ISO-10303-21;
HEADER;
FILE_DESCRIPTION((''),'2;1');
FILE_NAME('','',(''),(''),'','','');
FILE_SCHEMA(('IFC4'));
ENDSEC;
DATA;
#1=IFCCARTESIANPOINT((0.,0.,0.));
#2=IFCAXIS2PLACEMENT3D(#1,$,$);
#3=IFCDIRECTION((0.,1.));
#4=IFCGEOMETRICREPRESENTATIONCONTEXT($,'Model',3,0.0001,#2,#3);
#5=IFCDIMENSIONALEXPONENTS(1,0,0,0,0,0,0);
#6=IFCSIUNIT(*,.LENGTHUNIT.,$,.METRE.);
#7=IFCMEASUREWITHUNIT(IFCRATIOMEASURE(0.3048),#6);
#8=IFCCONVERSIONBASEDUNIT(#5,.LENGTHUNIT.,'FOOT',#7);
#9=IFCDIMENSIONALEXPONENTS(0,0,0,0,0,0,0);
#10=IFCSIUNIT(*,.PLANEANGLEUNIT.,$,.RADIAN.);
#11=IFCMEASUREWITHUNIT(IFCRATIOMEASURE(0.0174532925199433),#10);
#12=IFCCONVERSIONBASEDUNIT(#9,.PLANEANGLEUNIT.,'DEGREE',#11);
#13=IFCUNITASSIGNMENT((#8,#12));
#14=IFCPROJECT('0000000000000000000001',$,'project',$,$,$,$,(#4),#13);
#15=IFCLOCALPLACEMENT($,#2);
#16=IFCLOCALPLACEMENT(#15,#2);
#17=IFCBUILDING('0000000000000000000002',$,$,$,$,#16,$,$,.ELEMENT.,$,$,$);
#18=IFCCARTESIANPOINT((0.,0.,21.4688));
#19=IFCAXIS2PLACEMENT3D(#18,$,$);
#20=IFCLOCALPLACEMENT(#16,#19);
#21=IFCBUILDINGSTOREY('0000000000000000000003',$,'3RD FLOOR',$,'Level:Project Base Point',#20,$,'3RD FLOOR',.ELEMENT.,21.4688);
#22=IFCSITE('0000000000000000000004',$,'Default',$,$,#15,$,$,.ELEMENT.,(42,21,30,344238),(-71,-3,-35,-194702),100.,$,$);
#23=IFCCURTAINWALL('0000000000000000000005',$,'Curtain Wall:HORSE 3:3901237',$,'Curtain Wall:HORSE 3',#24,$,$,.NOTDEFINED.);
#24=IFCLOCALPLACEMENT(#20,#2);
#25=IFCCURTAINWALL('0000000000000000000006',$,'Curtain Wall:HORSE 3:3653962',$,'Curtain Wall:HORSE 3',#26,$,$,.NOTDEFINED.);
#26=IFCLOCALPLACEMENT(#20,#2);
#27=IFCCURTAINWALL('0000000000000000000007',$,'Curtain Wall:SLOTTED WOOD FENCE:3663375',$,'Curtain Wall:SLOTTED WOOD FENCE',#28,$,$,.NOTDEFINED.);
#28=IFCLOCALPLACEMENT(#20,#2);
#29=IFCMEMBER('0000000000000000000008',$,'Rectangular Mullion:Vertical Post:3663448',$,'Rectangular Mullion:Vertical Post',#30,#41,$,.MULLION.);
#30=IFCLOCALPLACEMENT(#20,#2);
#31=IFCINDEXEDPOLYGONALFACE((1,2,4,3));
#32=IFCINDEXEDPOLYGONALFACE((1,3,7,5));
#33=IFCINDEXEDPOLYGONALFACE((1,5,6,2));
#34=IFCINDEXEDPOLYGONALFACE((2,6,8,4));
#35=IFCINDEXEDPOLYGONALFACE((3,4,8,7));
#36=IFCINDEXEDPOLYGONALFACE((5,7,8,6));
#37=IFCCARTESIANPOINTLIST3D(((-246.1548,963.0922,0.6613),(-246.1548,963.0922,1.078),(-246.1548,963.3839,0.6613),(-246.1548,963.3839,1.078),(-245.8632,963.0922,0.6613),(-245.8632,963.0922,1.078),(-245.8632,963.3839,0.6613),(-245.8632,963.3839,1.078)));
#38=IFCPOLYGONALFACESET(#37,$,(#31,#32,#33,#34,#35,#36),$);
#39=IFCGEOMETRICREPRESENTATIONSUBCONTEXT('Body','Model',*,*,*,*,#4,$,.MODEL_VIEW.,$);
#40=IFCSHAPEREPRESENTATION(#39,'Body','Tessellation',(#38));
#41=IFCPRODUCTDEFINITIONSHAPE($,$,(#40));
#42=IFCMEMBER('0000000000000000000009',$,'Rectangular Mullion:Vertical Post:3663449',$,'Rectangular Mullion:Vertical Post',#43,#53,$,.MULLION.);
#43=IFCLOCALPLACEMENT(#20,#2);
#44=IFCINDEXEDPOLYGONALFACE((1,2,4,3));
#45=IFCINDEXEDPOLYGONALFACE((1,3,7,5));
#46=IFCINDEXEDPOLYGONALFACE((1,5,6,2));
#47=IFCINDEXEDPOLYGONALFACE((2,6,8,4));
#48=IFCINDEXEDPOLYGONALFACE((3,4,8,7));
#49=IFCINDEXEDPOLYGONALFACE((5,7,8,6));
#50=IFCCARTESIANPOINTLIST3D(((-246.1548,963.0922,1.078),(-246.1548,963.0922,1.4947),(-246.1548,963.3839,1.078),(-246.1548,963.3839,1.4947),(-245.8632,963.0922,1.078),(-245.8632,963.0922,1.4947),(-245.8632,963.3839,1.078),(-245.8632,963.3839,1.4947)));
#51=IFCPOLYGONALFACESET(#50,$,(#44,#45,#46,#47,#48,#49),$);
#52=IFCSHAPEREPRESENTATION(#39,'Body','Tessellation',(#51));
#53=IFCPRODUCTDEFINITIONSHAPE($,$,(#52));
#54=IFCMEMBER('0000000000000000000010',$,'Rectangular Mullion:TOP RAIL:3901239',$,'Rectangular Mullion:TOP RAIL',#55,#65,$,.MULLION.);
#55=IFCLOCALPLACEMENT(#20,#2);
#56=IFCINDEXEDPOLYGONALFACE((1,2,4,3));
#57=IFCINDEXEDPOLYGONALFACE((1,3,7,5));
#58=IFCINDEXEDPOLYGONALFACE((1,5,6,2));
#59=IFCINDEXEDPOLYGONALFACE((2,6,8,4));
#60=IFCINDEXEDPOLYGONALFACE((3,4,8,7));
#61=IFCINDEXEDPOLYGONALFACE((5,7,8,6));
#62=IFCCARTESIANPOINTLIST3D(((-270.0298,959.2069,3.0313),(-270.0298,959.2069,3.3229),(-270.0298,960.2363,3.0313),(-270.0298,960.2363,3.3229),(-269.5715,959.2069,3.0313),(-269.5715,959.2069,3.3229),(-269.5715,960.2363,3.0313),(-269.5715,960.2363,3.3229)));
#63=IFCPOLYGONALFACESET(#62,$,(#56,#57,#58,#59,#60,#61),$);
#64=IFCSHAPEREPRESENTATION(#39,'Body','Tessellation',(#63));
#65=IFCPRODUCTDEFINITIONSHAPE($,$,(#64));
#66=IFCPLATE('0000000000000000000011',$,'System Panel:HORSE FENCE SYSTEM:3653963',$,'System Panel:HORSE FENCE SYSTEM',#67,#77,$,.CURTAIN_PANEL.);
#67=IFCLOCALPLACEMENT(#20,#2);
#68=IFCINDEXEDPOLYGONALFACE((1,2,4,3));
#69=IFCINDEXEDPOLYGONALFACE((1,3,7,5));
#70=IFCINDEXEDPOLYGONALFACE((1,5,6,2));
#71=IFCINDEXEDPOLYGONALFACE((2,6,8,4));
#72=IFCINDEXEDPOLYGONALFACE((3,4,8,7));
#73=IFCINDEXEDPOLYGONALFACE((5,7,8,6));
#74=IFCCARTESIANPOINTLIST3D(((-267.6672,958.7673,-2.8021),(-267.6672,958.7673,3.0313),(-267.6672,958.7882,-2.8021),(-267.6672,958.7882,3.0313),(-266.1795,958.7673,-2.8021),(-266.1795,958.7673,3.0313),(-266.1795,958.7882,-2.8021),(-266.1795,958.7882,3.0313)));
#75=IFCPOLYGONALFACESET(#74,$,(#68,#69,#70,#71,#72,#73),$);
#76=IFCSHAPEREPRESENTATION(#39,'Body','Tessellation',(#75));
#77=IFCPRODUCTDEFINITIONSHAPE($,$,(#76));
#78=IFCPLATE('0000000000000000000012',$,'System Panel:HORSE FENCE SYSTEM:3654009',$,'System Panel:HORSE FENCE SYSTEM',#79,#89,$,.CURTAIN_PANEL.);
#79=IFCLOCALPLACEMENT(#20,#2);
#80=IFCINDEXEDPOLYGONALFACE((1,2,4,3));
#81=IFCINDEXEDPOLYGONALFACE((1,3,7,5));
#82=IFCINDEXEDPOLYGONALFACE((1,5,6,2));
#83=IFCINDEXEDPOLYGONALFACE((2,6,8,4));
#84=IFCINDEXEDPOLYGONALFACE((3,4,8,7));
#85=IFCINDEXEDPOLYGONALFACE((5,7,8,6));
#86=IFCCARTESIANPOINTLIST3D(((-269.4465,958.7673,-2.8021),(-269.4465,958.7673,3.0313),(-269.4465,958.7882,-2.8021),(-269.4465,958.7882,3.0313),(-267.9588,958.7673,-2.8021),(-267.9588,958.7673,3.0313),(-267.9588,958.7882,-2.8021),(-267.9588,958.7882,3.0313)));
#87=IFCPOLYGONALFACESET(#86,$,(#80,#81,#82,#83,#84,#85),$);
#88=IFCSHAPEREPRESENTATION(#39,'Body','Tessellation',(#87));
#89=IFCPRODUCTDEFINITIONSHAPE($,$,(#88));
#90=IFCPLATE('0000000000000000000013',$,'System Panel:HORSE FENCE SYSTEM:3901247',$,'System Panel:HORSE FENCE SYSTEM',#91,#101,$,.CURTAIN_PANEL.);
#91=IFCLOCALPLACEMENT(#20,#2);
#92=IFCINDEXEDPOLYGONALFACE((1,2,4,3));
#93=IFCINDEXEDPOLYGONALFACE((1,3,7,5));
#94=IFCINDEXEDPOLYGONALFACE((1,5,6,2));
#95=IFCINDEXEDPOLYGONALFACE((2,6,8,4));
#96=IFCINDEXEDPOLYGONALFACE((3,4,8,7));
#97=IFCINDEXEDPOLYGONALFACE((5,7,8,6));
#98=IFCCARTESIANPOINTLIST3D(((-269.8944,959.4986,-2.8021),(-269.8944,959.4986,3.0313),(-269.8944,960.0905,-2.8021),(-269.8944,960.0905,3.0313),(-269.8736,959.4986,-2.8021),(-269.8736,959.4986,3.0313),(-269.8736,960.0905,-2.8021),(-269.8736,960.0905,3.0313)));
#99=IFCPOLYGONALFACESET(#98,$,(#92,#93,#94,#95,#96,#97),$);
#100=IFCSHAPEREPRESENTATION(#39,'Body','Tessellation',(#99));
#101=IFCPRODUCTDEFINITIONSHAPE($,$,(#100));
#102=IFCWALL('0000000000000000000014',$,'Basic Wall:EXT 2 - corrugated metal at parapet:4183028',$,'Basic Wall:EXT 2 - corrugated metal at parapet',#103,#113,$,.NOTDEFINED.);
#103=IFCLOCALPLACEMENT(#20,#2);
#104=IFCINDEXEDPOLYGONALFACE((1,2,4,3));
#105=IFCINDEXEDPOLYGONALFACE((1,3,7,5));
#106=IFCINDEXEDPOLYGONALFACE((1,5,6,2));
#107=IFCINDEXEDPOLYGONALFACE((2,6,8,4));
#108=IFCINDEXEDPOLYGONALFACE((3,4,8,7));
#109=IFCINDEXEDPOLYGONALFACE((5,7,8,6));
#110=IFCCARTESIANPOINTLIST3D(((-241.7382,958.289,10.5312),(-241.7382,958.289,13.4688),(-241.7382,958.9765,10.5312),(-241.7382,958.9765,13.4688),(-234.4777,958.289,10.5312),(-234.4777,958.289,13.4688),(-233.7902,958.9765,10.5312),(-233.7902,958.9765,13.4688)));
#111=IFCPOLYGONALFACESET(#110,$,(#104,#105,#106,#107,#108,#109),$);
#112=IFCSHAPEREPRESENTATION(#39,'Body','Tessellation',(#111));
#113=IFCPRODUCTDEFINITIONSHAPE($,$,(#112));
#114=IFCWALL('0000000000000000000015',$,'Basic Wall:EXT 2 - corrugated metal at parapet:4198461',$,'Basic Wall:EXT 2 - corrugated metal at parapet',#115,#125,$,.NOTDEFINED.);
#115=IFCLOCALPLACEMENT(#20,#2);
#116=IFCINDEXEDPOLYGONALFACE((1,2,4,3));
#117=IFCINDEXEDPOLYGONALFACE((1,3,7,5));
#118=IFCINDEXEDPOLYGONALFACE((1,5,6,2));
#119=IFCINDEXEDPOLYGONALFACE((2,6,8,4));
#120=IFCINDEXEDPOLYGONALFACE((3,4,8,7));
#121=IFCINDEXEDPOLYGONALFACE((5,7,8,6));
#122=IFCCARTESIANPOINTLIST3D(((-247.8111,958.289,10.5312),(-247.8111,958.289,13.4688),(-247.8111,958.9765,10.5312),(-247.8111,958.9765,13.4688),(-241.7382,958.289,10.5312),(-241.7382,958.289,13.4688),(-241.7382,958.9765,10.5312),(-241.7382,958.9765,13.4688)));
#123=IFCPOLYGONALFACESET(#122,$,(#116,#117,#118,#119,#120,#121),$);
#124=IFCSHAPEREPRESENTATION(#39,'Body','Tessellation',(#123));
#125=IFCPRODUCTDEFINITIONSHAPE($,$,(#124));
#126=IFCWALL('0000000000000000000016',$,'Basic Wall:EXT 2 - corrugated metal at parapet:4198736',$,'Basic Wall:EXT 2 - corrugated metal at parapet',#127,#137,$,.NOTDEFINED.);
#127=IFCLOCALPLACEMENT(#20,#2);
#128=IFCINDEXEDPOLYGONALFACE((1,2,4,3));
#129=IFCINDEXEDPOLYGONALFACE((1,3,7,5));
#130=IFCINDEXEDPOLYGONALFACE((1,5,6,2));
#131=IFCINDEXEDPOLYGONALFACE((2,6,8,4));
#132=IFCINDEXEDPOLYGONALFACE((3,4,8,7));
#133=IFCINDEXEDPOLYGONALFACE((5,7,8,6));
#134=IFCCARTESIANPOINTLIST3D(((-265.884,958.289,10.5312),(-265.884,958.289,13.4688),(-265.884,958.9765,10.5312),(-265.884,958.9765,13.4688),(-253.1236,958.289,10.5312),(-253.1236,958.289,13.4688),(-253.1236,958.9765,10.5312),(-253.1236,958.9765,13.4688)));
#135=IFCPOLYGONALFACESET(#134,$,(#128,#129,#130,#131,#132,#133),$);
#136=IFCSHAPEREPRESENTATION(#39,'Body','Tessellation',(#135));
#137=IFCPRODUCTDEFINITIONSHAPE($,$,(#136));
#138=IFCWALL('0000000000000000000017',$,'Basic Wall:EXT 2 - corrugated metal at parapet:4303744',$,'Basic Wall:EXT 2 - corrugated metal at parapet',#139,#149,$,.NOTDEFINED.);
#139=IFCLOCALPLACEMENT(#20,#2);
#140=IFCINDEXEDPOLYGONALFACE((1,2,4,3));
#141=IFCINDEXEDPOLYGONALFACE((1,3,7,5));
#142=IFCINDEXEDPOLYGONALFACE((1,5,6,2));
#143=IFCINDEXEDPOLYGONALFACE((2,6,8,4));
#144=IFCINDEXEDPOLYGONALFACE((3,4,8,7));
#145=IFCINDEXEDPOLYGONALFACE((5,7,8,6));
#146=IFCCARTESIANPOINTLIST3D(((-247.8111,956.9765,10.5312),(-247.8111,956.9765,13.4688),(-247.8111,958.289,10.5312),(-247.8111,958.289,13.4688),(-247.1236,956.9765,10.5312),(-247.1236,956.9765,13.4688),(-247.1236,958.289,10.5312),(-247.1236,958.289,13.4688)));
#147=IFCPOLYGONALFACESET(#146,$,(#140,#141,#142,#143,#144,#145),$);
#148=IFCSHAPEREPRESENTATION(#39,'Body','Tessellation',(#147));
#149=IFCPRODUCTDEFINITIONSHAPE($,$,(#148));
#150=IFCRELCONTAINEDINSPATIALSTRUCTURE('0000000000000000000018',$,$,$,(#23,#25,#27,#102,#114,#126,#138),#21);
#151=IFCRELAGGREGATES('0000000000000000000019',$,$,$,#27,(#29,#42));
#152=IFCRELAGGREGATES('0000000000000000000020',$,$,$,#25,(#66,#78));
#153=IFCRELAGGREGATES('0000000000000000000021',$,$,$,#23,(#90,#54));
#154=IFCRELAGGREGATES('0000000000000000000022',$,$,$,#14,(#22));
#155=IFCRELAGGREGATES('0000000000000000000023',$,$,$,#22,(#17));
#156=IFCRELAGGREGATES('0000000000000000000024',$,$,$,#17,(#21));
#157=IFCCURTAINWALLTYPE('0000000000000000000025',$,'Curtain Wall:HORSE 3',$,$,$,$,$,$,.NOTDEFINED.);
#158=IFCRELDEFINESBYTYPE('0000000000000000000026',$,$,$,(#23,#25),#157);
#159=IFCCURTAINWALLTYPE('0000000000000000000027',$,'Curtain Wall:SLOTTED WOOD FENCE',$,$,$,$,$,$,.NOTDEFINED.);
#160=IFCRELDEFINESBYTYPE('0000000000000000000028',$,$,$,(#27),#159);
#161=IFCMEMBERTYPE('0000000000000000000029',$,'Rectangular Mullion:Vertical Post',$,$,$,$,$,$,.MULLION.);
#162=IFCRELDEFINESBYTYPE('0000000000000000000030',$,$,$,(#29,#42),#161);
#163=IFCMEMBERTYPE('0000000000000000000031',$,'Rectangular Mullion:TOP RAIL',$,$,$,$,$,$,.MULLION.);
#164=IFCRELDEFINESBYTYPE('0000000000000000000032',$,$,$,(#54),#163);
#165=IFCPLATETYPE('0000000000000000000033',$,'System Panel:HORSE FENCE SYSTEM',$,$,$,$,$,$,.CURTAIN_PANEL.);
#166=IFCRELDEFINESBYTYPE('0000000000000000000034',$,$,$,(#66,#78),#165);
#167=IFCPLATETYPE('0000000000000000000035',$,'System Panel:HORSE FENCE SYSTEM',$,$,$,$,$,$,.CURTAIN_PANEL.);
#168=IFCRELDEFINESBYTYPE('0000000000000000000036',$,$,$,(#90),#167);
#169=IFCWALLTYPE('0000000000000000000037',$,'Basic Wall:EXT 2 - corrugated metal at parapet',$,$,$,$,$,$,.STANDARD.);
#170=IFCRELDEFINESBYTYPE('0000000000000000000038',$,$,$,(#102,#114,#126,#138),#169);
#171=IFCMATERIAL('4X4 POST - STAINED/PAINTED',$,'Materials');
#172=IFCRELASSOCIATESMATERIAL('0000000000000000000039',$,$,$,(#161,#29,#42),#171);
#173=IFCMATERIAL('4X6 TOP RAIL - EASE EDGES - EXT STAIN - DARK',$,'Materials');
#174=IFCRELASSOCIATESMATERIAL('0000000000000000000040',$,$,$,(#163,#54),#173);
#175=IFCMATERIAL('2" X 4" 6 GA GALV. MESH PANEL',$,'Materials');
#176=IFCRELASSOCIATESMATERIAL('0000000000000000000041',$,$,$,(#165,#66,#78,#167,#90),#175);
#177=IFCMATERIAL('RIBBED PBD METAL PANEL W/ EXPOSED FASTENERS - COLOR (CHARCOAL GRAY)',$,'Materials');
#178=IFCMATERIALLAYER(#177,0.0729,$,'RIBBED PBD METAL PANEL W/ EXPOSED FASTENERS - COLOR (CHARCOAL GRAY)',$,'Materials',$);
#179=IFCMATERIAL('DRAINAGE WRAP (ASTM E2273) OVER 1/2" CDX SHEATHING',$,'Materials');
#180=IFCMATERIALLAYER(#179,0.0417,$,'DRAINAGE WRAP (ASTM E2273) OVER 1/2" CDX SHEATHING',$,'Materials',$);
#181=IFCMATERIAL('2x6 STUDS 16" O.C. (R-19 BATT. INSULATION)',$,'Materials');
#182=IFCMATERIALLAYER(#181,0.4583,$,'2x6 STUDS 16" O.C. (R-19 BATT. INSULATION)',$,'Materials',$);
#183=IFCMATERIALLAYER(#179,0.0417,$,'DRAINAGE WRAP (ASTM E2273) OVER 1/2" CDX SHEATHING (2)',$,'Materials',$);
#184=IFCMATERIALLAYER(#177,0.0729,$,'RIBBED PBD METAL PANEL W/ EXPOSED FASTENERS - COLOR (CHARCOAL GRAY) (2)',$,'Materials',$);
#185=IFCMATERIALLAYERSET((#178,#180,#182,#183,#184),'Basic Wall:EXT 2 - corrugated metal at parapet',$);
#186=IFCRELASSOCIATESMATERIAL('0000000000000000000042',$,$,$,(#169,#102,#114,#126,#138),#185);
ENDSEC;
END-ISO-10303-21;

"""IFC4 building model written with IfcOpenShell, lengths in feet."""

from ifc_helpers import new_model, entity, si_unit, converted_unit, direction, frame, frame_2d, origin, origin_2d_with_axis, place, context, subcontext, project, spatial, polyline, rectangle, outline, extrude, source, transform, mapped, material, layer, layer_set, layer_usage, material_profile, profile_set, profile_usage, type_object, type_shapes, element, aggregate, save


model = new_model("IFC4")

# Units and contexts
model_context = context("Model", 3, precision=0.0001, world=origin(), true_north=direction((0.0, 1.0)))
body_context = subcontext(model_context, "Body", "Model", "MODEL_VIEW")
ifc_project = project(units=[converted_unit("LENGTHUNIT", "FOOT", entity("IfcRatioMeasure", 0.3048), si_unit("LENGTHUNIT", "METRE"), dimensions=[1, 0, 0, 0, 0, 0, 0]), converted_unit("PLANEANGLEUNIT", "DEGREE", entity("IfcRatioMeasure", 0.0174532925199433), si_unit("PLANEANGLEUNIT", "RADIAN"), dimensions=[0, 0, 0, 0, 0, 0, 0])], contexts=[model_context])

# Site, building, storey
site_placement = place(None, origin())
site = spatial("IfcSite", under=ifc_project, at=site_placement, Name="Default", CompositionType="ELEMENT", RefLatitude=(42, 21, 30, 344238), RefLongitude=(-71, -3, -35, -194702), RefElevation=100.0)
building_placement = place(site_placement, origin())
building = spatial("IfcBuilding", under=site, at=building_placement, CompositionType="ELEMENT")
storey_placement = place(building_placement, frame((0.0, 0.0, 21.4688)))
storey = spatial("IfcBuildingStorey", under=building, at=storey_placement, Name="3RD FLOOR", ObjectType="Level:Project Base Point", LongName="3RD FLOOR", CompositionType="ELEMENT", Elevation=21.4688)

# Curtain walls, members
curtain_wall_type_1 = type_object("IfcCurtainWallType", Name="Curtain Wall:HORSE 3", PredefinedType="NOTDEFINED")
curtain_wall_1_placement = place(storey_placement, frame((0.0, 0.0, -21.4688)))
curtain_wall_1 = element("IfcCurtainWall", 1, at=curtain_wall_1_placement, inside=storey, type_object=curtain_wall_type_1, Name="Curtain Wall:HORSE 3:3901237", ObjectType="Curtain Wall:HORSE 3", PredefinedType="NOTDEFINED")
ifc_material_1 = material(Name="4X6 TOP RAIL - EASE EDGES - EXT STAIN - DARK", Category="Materials")
ifc_material_profile_1 = material_profile(ifc_material_1, rectangle(XDim=0.4583, YDim=0.2917, at=origin_2d_with_axis()), Name="TOP RAIL")
ifc_profile_set_1 = profile_set([ifc_material_profile_1], Name="TOP RAIL")
curtain_wall_2_placement = place(storey_placement, frame((0.0, 0.0, -21.4688)))
curtain_wall_2 = element("IfcCurtainWall", 2, at=curtain_wall_2_placement, inside=storey, type_object=curtain_wall_type_1, Name="Curtain Wall:HORSE 3:3653962", ObjectType="Curtain Wall:HORSE 3", PredefinedType="NOTDEFINED")
curtain_wall_type_2 = type_object("IfcCurtainWallType", Name="Curtain Wall:SLOTTED WOOD FENCE", PredefinedType="NOTDEFINED")
curtain_wall_3_placement = place(storey_placement, frame((0.0, 0.0, -21.4688)))
curtain_wall_3 = element("IfcCurtainWall", 3, at=curtain_wall_3_placement, inside=storey, type_object=curtain_wall_type_2, Name="Curtain Wall:SLOTTED WOOD FENCE:3663375", ObjectType="Curtain Wall:SLOTTED WOOD FENCE", PredefinedType="NOTDEFINED")
ifc_material_2 = material(Name="4X4 POST - STAINED/PAINTED", Category="Materials")
ifc_material_profile_2 = material_profile(ifc_material_2, rectangle(XDim=0.2917, YDim=0.2917, at=origin_2d_with_axis()), Name="Vertical Post")
ifc_profile_set_2 = profile_set([ifc_material_profile_2], Name="Vertical Post")
member_type_1 = type_object("IfcMemberType", Name="Rectangular Mullion:Vertical Post", PredefinedType="MULLION", material=ifc_profile_set_2)
shared_shape_1 = source(origin(), body_context, "Body", "SweptSolid", [
    extrude(rectangle(XDim=0.2917, YDim=0.2917, at=origin_2d_with_axis()), frame((-0.1458, 0.2083, -0.4167), z_axis=(0.0, 0.0, 1.0), x_axis=(0.0, -1.0, 0.0)), (0.0, 0.0, 1.0), 0.4167),
])
type_shapes(member_type_1, [shared_shape_1])
ifc_profile_usage_1 = profile_usage(ifc_profile_set_2)
member_1_placement = place(storey_placement, frame((-245.8007, 963.0922, 0.6613), z_axis=(0.0, 0.0, -1.0), x_axis=(0.0, -1.0, 0.0)))
member_1 = element("IfcMember", 4, at=member_1_placement, type_object=member_type_1, material=ifc_profile_usage_1, Name="Rectangular Mullion:Vertical Post:3663448", ObjectType="Rectangular Mullion:Vertical Post", PredefinedType="MULLION", context=body_context, shape_type="MappedRepresentation", body=[
    mapped(shared_shape_1, transform((0.0, 0.0, 0.0), scale=1.0)),
])
ifc_profile_usage_2 = profile_usage(ifc_profile_set_2)
member_2_placement = place(storey_placement, frame((-245.8007, 963.0922, 1.078), z_axis=(0.0, 0.0, -1.0), x_axis=(0.0, -1.0, 0.0)))
member_2 = element("IfcMember", 5, at=member_2_placement, type_object=member_type_1, material=ifc_profile_usage_2, Name="Rectangular Mullion:Vertical Post:3663449", ObjectType="Rectangular Mullion:Vertical Post", PredefinedType="MULLION", context=body_context, shape_type="MappedRepresentation", body=[
    mapped(shared_shape_1, transform((0.0, 0.0, 0.0), scale=1.0)),
])
aggregate(curtain_wall_3, [member_1, member_2])

# Member
ifc_profile_usage_3 = profile_usage(ifc_profile_set_1)
member_type_2 = type_object("IfcMemberType", Name="Rectangular Mullion:TOP RAIL", PredefinedType="MULLION", material=ifc_profile_set_1)
shared_shape_2 = source(origin(), body_context, "Body", "SweptSolid", [
    extrude(rectangle(XDim=0.4583, YDim=0.2917, at=origin_2d_with_axis()), frame((-0.1458, 0.0625, -1.0293), z_axis=(0.0, 0.0, 1.0), x_axis=(0.0, -1.0, 0.0)), (0.0, 0.0, 1.0), 1.0293),
])
type_shapes(member_type_2, [shared_shape_2])
member_3_placement = place(storey_placement, frame((-269.7382, 959.2069, 3.3229), z_axis=(0.0, -1.0, 0.0), x_axis=(0.0, 0.0, 1.0)))
member_3 = element("IfcMember", 6, at=member_3_placement, type_object=member_type_2, material=ifc_profile_usage_3, Name="Rectangular Mullion:TOP RAIL:3901239", ObjectType="Rectangular Mullion:TOP RAIL", PredefinedType="MULLION", context=body_context, shape_type="MappedRepresentation", body=[
    mapped(shared_shape_2, transform((0.0, 0.0, 0.0), scale=1.0)),
])

# Plates
ifc_material_3 = material(Name="2\" X 4\" 6 GA GALV. MESH PANEL", Category="Materials")
plate_type_1 = type_object("IfcPlateType", Name="System Panel:HORSE FENCE SYSTEM", PredefinedType="CURTAIN_PANEL", material=ifc_material_3)
shared_shape_3 = source(origin(), body_context, "Body", "SweptSolid", [
    extrude(rectangle(XDim=0.0208, YDim=1.4877, at=frame_2d((0.0, 0.0), x_axis=(1.0, 0.0))), frame((0.7438, 0.0104, 0.0), z_axis=(0.0, 0.0, 1.0), x_axis=(0.0, 1.0, 0.0)), (0.0, 0.0, 1.0), 5.8333),
])
type_shapes(plate_type_1, [shared_shape_3])
plate_1_placement = place(curtain_wall_2_placement, frame((-266.1795, 958.7882, 18.6667), z_axis=(0.0, 0.0, 1.0), x_axis=(-1.0, 0.0, 0.0)))
plate_1 = element("IfcPlate", 7, at=plate_1_placement, type_object=plate_type_1, material=ifc_material_3, Name="System Panel:HORSE FENCE SYSTEM:3653963", ObjectType="System Panel:HORSE FENCE SYSTEM", PredefinedType="CURTAIN_PANEL", context=body_context, shape_type="MappedRepresentation", body=[
    mapped(shared_shape_3, transform((0.0, 0.0, 0.0), scale=1.0)),
])
plate_2_placement = place(curtain_wall_2_placement, frame((-267.9588, 958.7882, 18.6667), z_axis=(0.0, 0.0, 1.0), x_axis=(-1.0, 0.0, 0.0)))
plate_2 = element("IfcPlate", 8, at=plate_2_placement, type_object=plate_type_1, material=ifc_material_3, Name="System Panel:HORSE FENCE SYSTEM:3654009", ObjectType="System Panel:HORSE FENCE SYSTEM", PredefinedType="CURTAIN_PANEL", context=body_context, shape_type="MappedRepresentation", body=[
    mapped(shared_shape_3, transform((0.0, 0.0, 0.0), scale=1.0)),
])
aggregate(curtain_wall_2, [plate_1, plate_2])
plate_type_2 = type_object("IfcPlateType", Name="System Panel:HORSE FENCE SYSTEM", PredefinedType="CURTAIN_PANEL", material=ifc_material_3)
shared_shape_4 = source(origin(), body_context, "Body", "SweptSolid", [
    extrude(rectangle(XDim=0.0208, YDim=0.5918, at=frame_2d((0.0, 0.0), x_axis=(1.0, 0.0))), frame((0.2959, 0.0104, 0.0), z_axis=(0.0, 0.0, 1.0), x_axis=(0.0, 1.0, 0.0)), (0.0, 0.0, 1.0), 5.8333),
])
type_shapes(plate_type_2, [shared_shape_4])
plate_3_placement = place(curtain_wall_1_placement, frame((-269.8944, 960.0905, 18.6667), z_axis=(0.0, 0.0, 1.0), x_axis=(0.0, -1.0, 0.0)))
plate_3 = element("IfcPlate", 9, at=plate_3_placement, type_object=plate_type_2, material=ifc_material_3, Name="System Panel:HORSE FENCE SYSTEM:3901247", ObjectType="System Panel:HORSE FENCE SYSTEM", PredefinedType="CURTAIN_PANEL", context=body_context, shape_type="MappedRepresentation", body=[
    mapped(shared_shape_4, transform((0.0, 0.0, 0.0), scale=1.0)),
])
aggregate(curtain_wall_1, [plate_3, member_3])

# Walls
ifc_material_4 = material(Name="RIBBED PBD METAL PANEL W/ EXPOSED FASTENERS - COLOR (CHARCOAL GRAY)", Category="Materials")
ifc_layer_1 = layer(ifc_material_4, 0.0729, Name="RIBBED PBD METAL PANEL W/ EXPOSED FASTENERS - COLOR (CHARCOAL GRAY)", Category="Materials")
ifc_material_5 = material(Name="DRAINAGE WRAP (ASTM E2273) OVER 1/2\" CDX SHEATHING", Category="Materials")
ifc_layer_2 = layer(ifc_material_5, 0.0417, Name="DRAINAGE WRAP (ASTM E2273) OVER 1/2\" CDX SHEATHING", Category="Materials")
ifc_material_6 = material(Name="2x6 STUDS 16\" O.C. (R-19 BATT. INSULATION)", Category="Materials")
ifc_layer_3 = layer(ifc_material_6, 0.4583, Name="2x6 STUDS 16\" O.C. (R-19 BATT. INSULATION)", Category="Materials")
ifc_layer_4 = layer(ifc_material_5, 0.0417, Name="DRAINAGE WRAP (ASTM E2273) OVER 1/2\" CDX SHEATHING (2)", Category="Materials")
ifc_layer_5 = layer(ifc_material_4, 0.0729, Name="RIBBED PBD METAL PANEL W/ EXPOSED FASTENERS - COLOR (CHARCOAL GRAY) (2)", Category="Materials")
ifc_layer_set_1 = layer_set([ifc_layer_1, ifc_layer_2, ifc_layer_3, ifc_layer_4, ifc_layer_5], Name="Basic Wall:EXT 2 - corrugated metal at parapet")
ifc_layer_usage_1 = layer_usage(ifc_layer_set_1, "AXIS2", "NEGATIVE", 0.3438)
wall_type_1 = type_object("IfcWallType", Name="Basic Wall:EXT 2 - corrugated metal at parapet", PredefinedType="STANDARD", material=ifc_layer_set_1)
wall_1_placement = place(storey_placement, frame((-241.7382, 958.6328, 10.5312)))
element("IfcWall", 10, at=wall_1_placement, inside=storey, type_object=wall_type_1, material=ifc_layer_usage_1, Name="Basic Wall:EXT 2 - corrugated metal at parapet:4183028", ObjectType="Basic Wall:EXT 2 - corrugated metal at parapet", PredefinedType="NOTDEFINED", context=body_context, shape_type="SweptSolid", body=[
    extrude(outline(polyline([(7.2604, -0.3437), (7.9479, 0.3438), (0.0, 0.3438), (0.0, -0.3438), (7.2604, -0.3437)])), origin(), (0.0, 0.0, 1.0), 2.9375),
])
ifc_layer_usage_2 = layer_usage(ifc_layer_set_1, "AXIS2", "NEGATIVE", 0.3438)
wall_2_placement = place(storey_placement, frame((-247.8111, 958.6328, 10.5312)))
element("IfcWall", 11, at=wall_2_placement, inside=storey, type_object=wall_type_1, material=ifc_layer_usage_2, Name="Basic Wall:EXT 2 - corrugated metal at parapet:4198461", ObjectType="Basic Wall:EXT 2 - corrugated metal at parapet", PredefinedType="NOTDEFINED", context=body_context, shape_type="SweptSolid", body=[
    extrude(rectangle(XDim=6.0729, YDim=0.6875, at=frame_2d((3.0365, 0.0), x_axis=(-1.0, 0.0))), origin(), (0.0, 0.0, 1.0), 2.9375),
])
ifc_layer_usage_3 = layer_usage(ifc_layer_set_1, "AXIS2", "NEGATIVE", 0.3438)
wall_3_placement = place(storey_placement, frame((-265.884, 958.6328, 10.5312)))
element("IfcWall", 12, at=wall_3_placement, inside=storey, type_object=wall_type_1, material=ifc_layer_usage_3, Name="Basic Wall:EXT 2 - corrugated metal at parapet:4198736", ObjectType="Basic Wall:EXT 2 - corrugated metal at parapet", PredefinedType="NOTDEFINED", context=body_context, shape_type="SweptSolid", body=[
    extrude(rectangle(XDim=12.7604, YDim=0.6875, at=frame_2d((6.3802, 0.0), x_axis=(-1.0, 0.0))), origin(), (0.0, 0.0, 1.0), 2.9375),
])
ifc_layer_usage_4 = layer_usage(ifc_layer_set_1, "AXIS2", "NEGATIVE", 0.3438)
wall_4_placement = place(storey_placement, frame((-247.4673, 956.9765, 10.5312), z_axis=(0.0, 0.0, 1.0), x_axis=(0.0, 1.0, 0.0)))
element("IfcWall", 13, at=wall_4_placement, inside=storey, type_object=wall_type_1, material=ifc_layer_usage_4, Name="Basic Wall:EXT 2 - corrugated metal at parapet:4303744", ObjectType="Basic Wall:EXT 2 - corrugated metal at parapet", PredefinedType="NOTDEFINED", context=body_context, shape_type="SweptSolid", body=[
    extrude(rectangle(XDim=1.3125, YDim=0.6875, at=frame_2d((0.6563, 0.0), x_axis=(-1.0, 0.0))), origin(), (0.0, 0.0, 1.0), 2.9375),
])

save(model, "model.ifc")
